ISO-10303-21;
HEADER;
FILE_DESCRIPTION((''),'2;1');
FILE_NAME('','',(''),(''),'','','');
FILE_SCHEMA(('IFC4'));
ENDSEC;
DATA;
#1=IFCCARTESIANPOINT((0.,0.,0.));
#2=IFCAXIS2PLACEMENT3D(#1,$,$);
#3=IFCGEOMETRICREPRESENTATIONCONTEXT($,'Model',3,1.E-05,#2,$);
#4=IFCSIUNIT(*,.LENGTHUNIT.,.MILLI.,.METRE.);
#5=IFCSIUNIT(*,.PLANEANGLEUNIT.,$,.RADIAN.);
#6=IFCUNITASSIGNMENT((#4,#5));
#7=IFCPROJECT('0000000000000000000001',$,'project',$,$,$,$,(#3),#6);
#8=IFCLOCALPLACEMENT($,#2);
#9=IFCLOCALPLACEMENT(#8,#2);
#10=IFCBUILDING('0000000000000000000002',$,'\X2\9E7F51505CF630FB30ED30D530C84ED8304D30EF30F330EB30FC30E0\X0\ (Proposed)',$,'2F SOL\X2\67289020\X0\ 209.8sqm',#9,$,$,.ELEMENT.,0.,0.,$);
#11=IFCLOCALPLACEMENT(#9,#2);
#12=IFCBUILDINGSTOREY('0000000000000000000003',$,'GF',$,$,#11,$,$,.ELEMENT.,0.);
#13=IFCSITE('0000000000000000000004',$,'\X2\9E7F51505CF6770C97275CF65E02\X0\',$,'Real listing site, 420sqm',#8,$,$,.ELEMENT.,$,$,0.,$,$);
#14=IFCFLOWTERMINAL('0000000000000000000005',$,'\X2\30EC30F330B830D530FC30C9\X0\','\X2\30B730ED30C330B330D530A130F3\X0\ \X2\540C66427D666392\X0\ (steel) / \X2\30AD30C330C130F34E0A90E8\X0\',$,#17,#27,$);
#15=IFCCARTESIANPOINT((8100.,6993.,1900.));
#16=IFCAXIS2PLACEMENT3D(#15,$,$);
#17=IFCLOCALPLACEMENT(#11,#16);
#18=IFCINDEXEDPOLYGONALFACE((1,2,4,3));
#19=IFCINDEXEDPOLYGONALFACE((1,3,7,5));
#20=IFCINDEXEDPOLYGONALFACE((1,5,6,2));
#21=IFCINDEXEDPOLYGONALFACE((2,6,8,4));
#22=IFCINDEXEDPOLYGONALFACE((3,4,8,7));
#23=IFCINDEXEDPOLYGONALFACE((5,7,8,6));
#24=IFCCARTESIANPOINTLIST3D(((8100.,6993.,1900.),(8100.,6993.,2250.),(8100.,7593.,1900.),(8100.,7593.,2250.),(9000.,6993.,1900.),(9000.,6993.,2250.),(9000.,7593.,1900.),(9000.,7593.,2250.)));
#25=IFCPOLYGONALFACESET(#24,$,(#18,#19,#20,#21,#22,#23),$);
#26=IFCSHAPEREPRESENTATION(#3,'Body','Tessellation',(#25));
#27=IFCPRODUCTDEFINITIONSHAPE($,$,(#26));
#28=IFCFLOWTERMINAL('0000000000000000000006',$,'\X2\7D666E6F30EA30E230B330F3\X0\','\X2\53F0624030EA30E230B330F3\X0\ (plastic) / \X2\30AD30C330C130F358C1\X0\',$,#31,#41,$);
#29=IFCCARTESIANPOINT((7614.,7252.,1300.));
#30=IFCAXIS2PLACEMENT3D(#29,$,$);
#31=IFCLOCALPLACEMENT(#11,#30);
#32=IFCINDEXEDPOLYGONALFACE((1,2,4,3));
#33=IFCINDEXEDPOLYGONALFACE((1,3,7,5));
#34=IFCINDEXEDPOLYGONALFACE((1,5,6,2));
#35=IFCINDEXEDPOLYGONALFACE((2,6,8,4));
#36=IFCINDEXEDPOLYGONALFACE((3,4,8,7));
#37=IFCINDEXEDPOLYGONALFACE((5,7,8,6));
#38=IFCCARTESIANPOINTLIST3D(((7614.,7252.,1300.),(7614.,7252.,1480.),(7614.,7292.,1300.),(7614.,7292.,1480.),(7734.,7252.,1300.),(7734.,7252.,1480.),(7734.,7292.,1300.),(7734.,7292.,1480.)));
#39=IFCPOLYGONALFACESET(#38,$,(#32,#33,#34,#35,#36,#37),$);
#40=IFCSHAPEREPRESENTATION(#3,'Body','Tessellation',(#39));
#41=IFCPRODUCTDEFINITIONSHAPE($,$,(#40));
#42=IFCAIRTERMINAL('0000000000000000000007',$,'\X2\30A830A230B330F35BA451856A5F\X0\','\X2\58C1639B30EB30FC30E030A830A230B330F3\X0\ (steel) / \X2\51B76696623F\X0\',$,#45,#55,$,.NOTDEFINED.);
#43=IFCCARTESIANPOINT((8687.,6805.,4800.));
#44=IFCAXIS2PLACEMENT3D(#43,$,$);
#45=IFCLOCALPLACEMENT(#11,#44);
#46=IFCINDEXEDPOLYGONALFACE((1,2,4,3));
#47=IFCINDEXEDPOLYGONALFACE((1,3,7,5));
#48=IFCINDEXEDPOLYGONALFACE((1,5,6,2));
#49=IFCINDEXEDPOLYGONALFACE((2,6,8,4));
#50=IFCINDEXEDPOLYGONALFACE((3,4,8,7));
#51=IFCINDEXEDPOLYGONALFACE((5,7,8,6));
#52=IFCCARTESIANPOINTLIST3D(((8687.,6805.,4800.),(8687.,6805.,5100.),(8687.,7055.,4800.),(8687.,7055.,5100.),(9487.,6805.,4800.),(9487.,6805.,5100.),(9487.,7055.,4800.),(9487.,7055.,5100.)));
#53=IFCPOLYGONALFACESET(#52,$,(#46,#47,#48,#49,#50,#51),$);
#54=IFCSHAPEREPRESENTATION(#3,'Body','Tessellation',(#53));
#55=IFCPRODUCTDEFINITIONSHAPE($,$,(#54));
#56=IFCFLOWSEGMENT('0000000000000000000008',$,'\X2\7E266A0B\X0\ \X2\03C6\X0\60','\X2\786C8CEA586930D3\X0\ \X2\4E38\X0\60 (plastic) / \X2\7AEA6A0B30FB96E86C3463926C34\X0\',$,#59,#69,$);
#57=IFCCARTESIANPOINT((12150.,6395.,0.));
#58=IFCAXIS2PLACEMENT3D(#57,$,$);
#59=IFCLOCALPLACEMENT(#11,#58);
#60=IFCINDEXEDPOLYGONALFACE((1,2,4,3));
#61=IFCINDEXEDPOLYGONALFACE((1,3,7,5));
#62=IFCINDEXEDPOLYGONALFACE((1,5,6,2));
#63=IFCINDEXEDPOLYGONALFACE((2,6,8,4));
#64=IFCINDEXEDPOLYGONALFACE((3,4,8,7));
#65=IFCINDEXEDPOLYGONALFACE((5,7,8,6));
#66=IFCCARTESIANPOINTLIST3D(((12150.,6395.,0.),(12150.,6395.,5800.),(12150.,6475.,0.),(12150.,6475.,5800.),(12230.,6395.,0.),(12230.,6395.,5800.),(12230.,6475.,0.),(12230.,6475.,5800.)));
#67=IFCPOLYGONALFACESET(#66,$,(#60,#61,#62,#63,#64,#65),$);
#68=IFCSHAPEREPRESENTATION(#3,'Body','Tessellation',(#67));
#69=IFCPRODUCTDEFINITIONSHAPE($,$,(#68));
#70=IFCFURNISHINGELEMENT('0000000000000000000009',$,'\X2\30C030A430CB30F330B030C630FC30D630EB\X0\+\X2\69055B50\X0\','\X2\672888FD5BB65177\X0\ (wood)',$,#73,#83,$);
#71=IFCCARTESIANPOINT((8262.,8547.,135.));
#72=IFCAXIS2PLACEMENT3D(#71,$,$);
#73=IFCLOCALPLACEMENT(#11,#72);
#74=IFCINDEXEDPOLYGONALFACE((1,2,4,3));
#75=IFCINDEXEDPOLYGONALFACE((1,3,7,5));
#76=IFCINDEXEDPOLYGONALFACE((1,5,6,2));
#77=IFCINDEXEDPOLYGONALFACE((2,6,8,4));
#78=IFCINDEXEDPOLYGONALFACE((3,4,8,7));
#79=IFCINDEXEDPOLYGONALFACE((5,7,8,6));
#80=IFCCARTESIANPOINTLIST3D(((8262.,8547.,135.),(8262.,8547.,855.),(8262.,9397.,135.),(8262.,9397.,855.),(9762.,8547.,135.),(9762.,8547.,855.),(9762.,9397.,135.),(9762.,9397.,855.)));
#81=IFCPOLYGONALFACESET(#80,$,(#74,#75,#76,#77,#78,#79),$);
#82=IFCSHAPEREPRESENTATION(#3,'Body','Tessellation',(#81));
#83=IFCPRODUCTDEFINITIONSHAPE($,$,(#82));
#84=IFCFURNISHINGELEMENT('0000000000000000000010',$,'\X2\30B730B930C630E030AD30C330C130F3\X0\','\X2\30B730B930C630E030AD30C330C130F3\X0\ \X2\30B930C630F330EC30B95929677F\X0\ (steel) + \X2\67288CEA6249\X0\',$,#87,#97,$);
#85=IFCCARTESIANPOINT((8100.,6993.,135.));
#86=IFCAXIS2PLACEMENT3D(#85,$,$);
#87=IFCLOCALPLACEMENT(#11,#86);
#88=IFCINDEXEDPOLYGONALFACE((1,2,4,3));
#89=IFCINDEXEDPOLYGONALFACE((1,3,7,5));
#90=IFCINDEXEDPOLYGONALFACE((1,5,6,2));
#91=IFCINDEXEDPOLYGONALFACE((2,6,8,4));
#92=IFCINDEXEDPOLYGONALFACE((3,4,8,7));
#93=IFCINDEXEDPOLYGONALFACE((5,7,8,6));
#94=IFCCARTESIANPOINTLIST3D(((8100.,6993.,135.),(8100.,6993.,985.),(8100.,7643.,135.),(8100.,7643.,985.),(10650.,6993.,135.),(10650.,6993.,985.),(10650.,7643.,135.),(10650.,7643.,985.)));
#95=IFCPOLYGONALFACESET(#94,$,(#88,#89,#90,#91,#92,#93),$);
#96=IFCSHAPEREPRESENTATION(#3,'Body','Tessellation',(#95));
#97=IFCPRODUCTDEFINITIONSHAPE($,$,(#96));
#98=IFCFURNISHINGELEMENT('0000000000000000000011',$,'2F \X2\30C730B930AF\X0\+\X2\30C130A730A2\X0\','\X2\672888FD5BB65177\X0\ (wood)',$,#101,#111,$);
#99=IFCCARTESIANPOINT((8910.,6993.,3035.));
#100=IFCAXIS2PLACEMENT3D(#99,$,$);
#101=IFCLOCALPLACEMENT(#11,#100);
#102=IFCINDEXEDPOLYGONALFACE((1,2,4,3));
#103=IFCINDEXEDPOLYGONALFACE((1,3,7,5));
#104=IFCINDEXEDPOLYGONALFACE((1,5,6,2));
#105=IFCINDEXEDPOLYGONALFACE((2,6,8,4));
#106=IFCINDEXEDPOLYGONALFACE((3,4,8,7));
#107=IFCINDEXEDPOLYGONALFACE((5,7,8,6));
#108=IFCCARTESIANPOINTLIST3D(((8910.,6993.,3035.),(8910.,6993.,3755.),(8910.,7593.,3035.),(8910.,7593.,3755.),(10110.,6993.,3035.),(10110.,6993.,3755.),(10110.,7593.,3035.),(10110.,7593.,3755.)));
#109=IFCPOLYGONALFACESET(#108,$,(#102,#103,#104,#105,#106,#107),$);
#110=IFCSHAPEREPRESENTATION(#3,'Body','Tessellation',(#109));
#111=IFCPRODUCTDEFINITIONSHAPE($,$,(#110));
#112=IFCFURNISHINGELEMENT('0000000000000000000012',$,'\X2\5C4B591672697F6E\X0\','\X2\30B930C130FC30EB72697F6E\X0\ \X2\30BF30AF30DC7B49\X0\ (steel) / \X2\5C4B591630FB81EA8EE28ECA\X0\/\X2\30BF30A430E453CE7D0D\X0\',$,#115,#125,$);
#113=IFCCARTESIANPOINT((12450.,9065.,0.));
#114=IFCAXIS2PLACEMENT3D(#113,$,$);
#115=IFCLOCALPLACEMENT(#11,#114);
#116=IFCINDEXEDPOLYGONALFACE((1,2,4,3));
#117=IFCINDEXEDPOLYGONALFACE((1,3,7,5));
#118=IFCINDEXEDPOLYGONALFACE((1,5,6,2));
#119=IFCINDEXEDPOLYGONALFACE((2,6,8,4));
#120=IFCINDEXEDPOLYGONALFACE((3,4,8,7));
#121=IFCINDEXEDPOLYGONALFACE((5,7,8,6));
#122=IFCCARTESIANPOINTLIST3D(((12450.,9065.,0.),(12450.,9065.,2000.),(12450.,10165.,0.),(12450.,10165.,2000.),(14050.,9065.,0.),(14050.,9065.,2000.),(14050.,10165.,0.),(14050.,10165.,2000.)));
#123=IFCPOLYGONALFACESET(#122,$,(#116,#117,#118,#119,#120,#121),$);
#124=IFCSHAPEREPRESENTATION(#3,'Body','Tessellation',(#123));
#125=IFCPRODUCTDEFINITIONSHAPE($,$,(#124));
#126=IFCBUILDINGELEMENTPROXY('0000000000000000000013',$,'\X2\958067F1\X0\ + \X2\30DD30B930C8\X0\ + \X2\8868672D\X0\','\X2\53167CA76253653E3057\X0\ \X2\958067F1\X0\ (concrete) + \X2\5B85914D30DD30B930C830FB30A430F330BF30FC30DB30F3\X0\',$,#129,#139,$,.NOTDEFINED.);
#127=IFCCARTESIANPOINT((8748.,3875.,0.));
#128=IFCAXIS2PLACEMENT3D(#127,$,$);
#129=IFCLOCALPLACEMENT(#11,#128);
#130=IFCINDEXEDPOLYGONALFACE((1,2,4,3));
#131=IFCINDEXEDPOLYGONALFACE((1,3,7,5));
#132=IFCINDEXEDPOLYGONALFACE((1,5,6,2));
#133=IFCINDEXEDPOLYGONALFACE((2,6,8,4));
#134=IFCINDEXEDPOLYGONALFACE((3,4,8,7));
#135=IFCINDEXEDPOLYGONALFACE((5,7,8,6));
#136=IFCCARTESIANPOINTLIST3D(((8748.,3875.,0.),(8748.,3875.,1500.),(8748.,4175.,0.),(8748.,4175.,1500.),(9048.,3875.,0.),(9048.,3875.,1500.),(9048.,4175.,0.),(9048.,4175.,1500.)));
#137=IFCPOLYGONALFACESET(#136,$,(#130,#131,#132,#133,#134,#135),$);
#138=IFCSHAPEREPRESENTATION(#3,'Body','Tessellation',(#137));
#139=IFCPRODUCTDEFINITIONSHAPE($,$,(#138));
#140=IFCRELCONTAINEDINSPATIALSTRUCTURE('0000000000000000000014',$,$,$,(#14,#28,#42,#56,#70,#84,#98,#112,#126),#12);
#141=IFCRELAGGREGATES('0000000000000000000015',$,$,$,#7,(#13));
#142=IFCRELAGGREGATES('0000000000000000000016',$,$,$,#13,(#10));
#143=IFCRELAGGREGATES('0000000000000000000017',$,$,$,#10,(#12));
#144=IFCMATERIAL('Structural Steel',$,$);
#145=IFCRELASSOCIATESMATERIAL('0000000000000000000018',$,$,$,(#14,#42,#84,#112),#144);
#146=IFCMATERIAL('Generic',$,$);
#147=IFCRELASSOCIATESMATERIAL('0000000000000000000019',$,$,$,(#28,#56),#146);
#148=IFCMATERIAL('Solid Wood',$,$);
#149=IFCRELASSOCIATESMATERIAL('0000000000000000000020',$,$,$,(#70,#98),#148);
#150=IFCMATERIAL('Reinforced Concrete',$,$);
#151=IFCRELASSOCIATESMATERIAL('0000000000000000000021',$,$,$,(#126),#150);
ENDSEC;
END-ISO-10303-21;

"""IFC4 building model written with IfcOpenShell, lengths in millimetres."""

from ifc_helpers import new_model, si_unit, frame, frame_2d, origin, place, context, project, spatial, rectangle, extrude, material, element, save


model = new_model("IFC4")

# Units and contexts
model_context = context("Model", 3, precision=1e-05, world=origin())
ifc_project = project(units=[si_unit("LENGTHUNIT", "METRE", prefix="MILLI"), si_unit("PLANEANGLEUNIT", "RADIAN")], contexts=[model_context])

# Site, building, storey
site_placement = place(None, origin())
site = spatial("IfcSite", under=ifc_project, at=site_placement, Name="鹿児島県霧島市", ObjectType="Real listing site, 420sqm", CompositionType="ELEMENT", RefElevation=0.0)
building_placement = place(site_placement, origin())
building = spatial("IfcBuilding", under=site, at=building_placement, Name="鹿児島・ロフト付きワンルーム (Proposed)", ObjectType="2F SOL木造 209.8sqm", CompositionType="ELEMENT", ElevationOfRefHeight=0.0, ElevationOfTerrain=0.0)
storey_placement = place(building_placement, origin())
storey = spatial("IfcBuildingStorey", under=building, at=storey_placement, Name="GF", CompositionType="ELEMENT", Elevation=0.0)

# Shared definitions
ifc_material_1 = material(Name="Solid Wood")

# Shared definitions
ifc_material_2 = material(Name="Reinforced Concrete")

# Shared definitions
ifc_material_3 = material(Name="Structural Steel")

# Flow terminals
flow_terminal_1_placement = place(storey_placement, frame((8100.0, 6993.0, 1900.0)))
element("IfcFlowTerminal", 1, at=flow_terminal_1_placement, inside=storey, material=ifc_material_3, Name="レンジフード", Description="シロッコファン 同時給排 (steel) / キッチン上部", context=model_context, shape_type="SweptSolid", body=[
    extrude(rectangle(XDim=900.0, YDim=600.0, at=frame_2d((450.0, 300.0))), frame((8100.0, 6993.0, 1900.0)), (0.0, 0.0, 1.0), 350.0),
])
ifc_material_4 = material(Name="Generic")
flow_terminal_2_placement = place(storey_placement, frame((7614.0, 7252.0, 1300.0)))
element("IfcFlowTerminal", 2, at=flow_terminal_2_placement, inside=storey, material=ifc_material_4, Name="給湯リモコン", Description="台所リモコン (plastic) / キッチン壁", context=model_context, shape_type="SweptSolid", body=[
    extrude(rectangle(XDim=120.0, YDim=40.0, at=frame_2d((60.0, 20.0))), frame((7614.0, 7252.0, 1300.0)), (0.0, 0.0, 1.0), 180.0),
])

# Air terminal
air_terminal_placement = place(storey_placement, frame((8687.0, 6805.0, 4800.0)))
element("IfcAirTerminal", 3, at=air_terminal_placement, inside=storey, material=ifc_material_3, Name="エアコン室内機", Description="壁掛ルームエアコン (steel) / 冷暖房", PredefinedType="NOTDEFINED", context=model_context, shape_type="SweptSolid", body=[
    extrude(rectangle(XDim=800.0, YDim=250.0, at=frame_2d((400.0, 125.0))), frame((8687.0, 6805.0, 4800.0)), (0.0, 0.0, 1.0), 300.0),
])

# Flow segment
flow_segment_placement = place(storey_placement, frame((12150.0, 6395.0, 0.0)))
element("IfcFlowSegment", 4, at=flow_segment_placement, inside=storey, material=ifc_material_4, Name="縦樋 φ60", Description="硬質塩ビ 丸60 (plastic) / 竪樋・雨水排水", context=model_context, shape_type="SweptSolid", body=[
    extrude(rectangle(XDim=80.0, YDim=80.0, at=frame_2d((40.0, 40.0))), frame((12150.0, 6395.0, 0.0)), (0.0, 0.0, 1.0), 5800.0),
])

# Furnishing elements
furnishing_1_placement = place(storey_placement, frame((8262.0, 8547.0, 135.0)))
element("IfcFurnishingElement", 5, at=furnishing_1_placement, inside=storey, material=ifc_material_1, Name="ダイニングテーブル+椅子", Description="木製家具 (wood)", context=model_context, shape_type="SweptSolid", body=[
    extrude(rectangle(XDim=1500.0, YDim=850.0, at=frame_2d((750.0, 425.0))), frame((8262.0, 8547.0, 135.0)), (0.0, 0.0, 1.0), 720.0),
])
furnishing_2_placement = place(storey_placement, frame((8100.0, 6993.0, 135.0)))
element("IfcFurnishingElement", 6, at=furnishing_2_placement, inside=storey, material=ifc_material_3, Name="システムキッチン", Description="システムキッチン ステンレス天板 (steel) + 木質扉", context=model_context, shape_type="SweptSolid", body=[
    extrude(rectangle(XDim=2550.0, YDim=650.0, at=frame_2d((1275.0, 325.0))), frame((8100.0, 6993.0, 135.0)), (0.0, 0.0, 1.0), 850.0),
])
furnishing_3_placement = place(storey_placement, frame((8910.0, 6993.0, 3035.0)))
element("IfcFurnishingElement", 7, at=furnishing_3_placement, inside=storey, material=ifc_material_1, Name="2F デスク+チェア", Description="木製家具 (wood)", context=model_context, shape_type="SweptSolid", body=[
    extrude(rectangle(XDim=1200.0, YDim=600.0, at=frame_2d((600.0, 300.0))), frame((8910.0, 6993.0, 3035.0)), (0.0, 0.0, 1.0), 720.0),
])
furnishing_4_placement = place(storey_placement, frame((12450.0, 9065.0, 0.0)))
element("IfcFurnishingElement", 8, at=furnishing_4_placement, inside=storey, material=ifc_material_3, Name="屋外物置", Description="スチール物置 タクボ等 (steel) / 屋外・自転車/タイヤ収納", context=model_context, shape_type="SweptSolid", body=[
    extrude(rectangle(XDim=1600.0, YDim=1100.0, at=frame_2d((800.0, 550.0))), frame((12450.0, 9065.0, 0.0)), (0.0, 0.0, 1.0), 2000.0),
])

# Building element proxy
proxy_placement = place(storey_placement, frame((8748.0, 3875.0, 0.0)))
element("IfcBuildingElementProxy", 9, at=proxy_placement, inside=storey, material=ifc_material_2, Name="門柱 + ポスト + 表札", Description="化粧打放し 門柱 (concrete) + 宅配ポスト・インターホン", PredefinedType="NOTDEFINED", context=model_context, shape_type="SweptSolid", body=[
    extrude(rectangle(XDim=300.0, YDim=300.0, at=frame_2d((150.0, 150.0))), frame((8748.0, 3875.0, 0.0)), (0.0, 0.0, 1.0), 1500.0),
])

save(model, "model.ifc")
